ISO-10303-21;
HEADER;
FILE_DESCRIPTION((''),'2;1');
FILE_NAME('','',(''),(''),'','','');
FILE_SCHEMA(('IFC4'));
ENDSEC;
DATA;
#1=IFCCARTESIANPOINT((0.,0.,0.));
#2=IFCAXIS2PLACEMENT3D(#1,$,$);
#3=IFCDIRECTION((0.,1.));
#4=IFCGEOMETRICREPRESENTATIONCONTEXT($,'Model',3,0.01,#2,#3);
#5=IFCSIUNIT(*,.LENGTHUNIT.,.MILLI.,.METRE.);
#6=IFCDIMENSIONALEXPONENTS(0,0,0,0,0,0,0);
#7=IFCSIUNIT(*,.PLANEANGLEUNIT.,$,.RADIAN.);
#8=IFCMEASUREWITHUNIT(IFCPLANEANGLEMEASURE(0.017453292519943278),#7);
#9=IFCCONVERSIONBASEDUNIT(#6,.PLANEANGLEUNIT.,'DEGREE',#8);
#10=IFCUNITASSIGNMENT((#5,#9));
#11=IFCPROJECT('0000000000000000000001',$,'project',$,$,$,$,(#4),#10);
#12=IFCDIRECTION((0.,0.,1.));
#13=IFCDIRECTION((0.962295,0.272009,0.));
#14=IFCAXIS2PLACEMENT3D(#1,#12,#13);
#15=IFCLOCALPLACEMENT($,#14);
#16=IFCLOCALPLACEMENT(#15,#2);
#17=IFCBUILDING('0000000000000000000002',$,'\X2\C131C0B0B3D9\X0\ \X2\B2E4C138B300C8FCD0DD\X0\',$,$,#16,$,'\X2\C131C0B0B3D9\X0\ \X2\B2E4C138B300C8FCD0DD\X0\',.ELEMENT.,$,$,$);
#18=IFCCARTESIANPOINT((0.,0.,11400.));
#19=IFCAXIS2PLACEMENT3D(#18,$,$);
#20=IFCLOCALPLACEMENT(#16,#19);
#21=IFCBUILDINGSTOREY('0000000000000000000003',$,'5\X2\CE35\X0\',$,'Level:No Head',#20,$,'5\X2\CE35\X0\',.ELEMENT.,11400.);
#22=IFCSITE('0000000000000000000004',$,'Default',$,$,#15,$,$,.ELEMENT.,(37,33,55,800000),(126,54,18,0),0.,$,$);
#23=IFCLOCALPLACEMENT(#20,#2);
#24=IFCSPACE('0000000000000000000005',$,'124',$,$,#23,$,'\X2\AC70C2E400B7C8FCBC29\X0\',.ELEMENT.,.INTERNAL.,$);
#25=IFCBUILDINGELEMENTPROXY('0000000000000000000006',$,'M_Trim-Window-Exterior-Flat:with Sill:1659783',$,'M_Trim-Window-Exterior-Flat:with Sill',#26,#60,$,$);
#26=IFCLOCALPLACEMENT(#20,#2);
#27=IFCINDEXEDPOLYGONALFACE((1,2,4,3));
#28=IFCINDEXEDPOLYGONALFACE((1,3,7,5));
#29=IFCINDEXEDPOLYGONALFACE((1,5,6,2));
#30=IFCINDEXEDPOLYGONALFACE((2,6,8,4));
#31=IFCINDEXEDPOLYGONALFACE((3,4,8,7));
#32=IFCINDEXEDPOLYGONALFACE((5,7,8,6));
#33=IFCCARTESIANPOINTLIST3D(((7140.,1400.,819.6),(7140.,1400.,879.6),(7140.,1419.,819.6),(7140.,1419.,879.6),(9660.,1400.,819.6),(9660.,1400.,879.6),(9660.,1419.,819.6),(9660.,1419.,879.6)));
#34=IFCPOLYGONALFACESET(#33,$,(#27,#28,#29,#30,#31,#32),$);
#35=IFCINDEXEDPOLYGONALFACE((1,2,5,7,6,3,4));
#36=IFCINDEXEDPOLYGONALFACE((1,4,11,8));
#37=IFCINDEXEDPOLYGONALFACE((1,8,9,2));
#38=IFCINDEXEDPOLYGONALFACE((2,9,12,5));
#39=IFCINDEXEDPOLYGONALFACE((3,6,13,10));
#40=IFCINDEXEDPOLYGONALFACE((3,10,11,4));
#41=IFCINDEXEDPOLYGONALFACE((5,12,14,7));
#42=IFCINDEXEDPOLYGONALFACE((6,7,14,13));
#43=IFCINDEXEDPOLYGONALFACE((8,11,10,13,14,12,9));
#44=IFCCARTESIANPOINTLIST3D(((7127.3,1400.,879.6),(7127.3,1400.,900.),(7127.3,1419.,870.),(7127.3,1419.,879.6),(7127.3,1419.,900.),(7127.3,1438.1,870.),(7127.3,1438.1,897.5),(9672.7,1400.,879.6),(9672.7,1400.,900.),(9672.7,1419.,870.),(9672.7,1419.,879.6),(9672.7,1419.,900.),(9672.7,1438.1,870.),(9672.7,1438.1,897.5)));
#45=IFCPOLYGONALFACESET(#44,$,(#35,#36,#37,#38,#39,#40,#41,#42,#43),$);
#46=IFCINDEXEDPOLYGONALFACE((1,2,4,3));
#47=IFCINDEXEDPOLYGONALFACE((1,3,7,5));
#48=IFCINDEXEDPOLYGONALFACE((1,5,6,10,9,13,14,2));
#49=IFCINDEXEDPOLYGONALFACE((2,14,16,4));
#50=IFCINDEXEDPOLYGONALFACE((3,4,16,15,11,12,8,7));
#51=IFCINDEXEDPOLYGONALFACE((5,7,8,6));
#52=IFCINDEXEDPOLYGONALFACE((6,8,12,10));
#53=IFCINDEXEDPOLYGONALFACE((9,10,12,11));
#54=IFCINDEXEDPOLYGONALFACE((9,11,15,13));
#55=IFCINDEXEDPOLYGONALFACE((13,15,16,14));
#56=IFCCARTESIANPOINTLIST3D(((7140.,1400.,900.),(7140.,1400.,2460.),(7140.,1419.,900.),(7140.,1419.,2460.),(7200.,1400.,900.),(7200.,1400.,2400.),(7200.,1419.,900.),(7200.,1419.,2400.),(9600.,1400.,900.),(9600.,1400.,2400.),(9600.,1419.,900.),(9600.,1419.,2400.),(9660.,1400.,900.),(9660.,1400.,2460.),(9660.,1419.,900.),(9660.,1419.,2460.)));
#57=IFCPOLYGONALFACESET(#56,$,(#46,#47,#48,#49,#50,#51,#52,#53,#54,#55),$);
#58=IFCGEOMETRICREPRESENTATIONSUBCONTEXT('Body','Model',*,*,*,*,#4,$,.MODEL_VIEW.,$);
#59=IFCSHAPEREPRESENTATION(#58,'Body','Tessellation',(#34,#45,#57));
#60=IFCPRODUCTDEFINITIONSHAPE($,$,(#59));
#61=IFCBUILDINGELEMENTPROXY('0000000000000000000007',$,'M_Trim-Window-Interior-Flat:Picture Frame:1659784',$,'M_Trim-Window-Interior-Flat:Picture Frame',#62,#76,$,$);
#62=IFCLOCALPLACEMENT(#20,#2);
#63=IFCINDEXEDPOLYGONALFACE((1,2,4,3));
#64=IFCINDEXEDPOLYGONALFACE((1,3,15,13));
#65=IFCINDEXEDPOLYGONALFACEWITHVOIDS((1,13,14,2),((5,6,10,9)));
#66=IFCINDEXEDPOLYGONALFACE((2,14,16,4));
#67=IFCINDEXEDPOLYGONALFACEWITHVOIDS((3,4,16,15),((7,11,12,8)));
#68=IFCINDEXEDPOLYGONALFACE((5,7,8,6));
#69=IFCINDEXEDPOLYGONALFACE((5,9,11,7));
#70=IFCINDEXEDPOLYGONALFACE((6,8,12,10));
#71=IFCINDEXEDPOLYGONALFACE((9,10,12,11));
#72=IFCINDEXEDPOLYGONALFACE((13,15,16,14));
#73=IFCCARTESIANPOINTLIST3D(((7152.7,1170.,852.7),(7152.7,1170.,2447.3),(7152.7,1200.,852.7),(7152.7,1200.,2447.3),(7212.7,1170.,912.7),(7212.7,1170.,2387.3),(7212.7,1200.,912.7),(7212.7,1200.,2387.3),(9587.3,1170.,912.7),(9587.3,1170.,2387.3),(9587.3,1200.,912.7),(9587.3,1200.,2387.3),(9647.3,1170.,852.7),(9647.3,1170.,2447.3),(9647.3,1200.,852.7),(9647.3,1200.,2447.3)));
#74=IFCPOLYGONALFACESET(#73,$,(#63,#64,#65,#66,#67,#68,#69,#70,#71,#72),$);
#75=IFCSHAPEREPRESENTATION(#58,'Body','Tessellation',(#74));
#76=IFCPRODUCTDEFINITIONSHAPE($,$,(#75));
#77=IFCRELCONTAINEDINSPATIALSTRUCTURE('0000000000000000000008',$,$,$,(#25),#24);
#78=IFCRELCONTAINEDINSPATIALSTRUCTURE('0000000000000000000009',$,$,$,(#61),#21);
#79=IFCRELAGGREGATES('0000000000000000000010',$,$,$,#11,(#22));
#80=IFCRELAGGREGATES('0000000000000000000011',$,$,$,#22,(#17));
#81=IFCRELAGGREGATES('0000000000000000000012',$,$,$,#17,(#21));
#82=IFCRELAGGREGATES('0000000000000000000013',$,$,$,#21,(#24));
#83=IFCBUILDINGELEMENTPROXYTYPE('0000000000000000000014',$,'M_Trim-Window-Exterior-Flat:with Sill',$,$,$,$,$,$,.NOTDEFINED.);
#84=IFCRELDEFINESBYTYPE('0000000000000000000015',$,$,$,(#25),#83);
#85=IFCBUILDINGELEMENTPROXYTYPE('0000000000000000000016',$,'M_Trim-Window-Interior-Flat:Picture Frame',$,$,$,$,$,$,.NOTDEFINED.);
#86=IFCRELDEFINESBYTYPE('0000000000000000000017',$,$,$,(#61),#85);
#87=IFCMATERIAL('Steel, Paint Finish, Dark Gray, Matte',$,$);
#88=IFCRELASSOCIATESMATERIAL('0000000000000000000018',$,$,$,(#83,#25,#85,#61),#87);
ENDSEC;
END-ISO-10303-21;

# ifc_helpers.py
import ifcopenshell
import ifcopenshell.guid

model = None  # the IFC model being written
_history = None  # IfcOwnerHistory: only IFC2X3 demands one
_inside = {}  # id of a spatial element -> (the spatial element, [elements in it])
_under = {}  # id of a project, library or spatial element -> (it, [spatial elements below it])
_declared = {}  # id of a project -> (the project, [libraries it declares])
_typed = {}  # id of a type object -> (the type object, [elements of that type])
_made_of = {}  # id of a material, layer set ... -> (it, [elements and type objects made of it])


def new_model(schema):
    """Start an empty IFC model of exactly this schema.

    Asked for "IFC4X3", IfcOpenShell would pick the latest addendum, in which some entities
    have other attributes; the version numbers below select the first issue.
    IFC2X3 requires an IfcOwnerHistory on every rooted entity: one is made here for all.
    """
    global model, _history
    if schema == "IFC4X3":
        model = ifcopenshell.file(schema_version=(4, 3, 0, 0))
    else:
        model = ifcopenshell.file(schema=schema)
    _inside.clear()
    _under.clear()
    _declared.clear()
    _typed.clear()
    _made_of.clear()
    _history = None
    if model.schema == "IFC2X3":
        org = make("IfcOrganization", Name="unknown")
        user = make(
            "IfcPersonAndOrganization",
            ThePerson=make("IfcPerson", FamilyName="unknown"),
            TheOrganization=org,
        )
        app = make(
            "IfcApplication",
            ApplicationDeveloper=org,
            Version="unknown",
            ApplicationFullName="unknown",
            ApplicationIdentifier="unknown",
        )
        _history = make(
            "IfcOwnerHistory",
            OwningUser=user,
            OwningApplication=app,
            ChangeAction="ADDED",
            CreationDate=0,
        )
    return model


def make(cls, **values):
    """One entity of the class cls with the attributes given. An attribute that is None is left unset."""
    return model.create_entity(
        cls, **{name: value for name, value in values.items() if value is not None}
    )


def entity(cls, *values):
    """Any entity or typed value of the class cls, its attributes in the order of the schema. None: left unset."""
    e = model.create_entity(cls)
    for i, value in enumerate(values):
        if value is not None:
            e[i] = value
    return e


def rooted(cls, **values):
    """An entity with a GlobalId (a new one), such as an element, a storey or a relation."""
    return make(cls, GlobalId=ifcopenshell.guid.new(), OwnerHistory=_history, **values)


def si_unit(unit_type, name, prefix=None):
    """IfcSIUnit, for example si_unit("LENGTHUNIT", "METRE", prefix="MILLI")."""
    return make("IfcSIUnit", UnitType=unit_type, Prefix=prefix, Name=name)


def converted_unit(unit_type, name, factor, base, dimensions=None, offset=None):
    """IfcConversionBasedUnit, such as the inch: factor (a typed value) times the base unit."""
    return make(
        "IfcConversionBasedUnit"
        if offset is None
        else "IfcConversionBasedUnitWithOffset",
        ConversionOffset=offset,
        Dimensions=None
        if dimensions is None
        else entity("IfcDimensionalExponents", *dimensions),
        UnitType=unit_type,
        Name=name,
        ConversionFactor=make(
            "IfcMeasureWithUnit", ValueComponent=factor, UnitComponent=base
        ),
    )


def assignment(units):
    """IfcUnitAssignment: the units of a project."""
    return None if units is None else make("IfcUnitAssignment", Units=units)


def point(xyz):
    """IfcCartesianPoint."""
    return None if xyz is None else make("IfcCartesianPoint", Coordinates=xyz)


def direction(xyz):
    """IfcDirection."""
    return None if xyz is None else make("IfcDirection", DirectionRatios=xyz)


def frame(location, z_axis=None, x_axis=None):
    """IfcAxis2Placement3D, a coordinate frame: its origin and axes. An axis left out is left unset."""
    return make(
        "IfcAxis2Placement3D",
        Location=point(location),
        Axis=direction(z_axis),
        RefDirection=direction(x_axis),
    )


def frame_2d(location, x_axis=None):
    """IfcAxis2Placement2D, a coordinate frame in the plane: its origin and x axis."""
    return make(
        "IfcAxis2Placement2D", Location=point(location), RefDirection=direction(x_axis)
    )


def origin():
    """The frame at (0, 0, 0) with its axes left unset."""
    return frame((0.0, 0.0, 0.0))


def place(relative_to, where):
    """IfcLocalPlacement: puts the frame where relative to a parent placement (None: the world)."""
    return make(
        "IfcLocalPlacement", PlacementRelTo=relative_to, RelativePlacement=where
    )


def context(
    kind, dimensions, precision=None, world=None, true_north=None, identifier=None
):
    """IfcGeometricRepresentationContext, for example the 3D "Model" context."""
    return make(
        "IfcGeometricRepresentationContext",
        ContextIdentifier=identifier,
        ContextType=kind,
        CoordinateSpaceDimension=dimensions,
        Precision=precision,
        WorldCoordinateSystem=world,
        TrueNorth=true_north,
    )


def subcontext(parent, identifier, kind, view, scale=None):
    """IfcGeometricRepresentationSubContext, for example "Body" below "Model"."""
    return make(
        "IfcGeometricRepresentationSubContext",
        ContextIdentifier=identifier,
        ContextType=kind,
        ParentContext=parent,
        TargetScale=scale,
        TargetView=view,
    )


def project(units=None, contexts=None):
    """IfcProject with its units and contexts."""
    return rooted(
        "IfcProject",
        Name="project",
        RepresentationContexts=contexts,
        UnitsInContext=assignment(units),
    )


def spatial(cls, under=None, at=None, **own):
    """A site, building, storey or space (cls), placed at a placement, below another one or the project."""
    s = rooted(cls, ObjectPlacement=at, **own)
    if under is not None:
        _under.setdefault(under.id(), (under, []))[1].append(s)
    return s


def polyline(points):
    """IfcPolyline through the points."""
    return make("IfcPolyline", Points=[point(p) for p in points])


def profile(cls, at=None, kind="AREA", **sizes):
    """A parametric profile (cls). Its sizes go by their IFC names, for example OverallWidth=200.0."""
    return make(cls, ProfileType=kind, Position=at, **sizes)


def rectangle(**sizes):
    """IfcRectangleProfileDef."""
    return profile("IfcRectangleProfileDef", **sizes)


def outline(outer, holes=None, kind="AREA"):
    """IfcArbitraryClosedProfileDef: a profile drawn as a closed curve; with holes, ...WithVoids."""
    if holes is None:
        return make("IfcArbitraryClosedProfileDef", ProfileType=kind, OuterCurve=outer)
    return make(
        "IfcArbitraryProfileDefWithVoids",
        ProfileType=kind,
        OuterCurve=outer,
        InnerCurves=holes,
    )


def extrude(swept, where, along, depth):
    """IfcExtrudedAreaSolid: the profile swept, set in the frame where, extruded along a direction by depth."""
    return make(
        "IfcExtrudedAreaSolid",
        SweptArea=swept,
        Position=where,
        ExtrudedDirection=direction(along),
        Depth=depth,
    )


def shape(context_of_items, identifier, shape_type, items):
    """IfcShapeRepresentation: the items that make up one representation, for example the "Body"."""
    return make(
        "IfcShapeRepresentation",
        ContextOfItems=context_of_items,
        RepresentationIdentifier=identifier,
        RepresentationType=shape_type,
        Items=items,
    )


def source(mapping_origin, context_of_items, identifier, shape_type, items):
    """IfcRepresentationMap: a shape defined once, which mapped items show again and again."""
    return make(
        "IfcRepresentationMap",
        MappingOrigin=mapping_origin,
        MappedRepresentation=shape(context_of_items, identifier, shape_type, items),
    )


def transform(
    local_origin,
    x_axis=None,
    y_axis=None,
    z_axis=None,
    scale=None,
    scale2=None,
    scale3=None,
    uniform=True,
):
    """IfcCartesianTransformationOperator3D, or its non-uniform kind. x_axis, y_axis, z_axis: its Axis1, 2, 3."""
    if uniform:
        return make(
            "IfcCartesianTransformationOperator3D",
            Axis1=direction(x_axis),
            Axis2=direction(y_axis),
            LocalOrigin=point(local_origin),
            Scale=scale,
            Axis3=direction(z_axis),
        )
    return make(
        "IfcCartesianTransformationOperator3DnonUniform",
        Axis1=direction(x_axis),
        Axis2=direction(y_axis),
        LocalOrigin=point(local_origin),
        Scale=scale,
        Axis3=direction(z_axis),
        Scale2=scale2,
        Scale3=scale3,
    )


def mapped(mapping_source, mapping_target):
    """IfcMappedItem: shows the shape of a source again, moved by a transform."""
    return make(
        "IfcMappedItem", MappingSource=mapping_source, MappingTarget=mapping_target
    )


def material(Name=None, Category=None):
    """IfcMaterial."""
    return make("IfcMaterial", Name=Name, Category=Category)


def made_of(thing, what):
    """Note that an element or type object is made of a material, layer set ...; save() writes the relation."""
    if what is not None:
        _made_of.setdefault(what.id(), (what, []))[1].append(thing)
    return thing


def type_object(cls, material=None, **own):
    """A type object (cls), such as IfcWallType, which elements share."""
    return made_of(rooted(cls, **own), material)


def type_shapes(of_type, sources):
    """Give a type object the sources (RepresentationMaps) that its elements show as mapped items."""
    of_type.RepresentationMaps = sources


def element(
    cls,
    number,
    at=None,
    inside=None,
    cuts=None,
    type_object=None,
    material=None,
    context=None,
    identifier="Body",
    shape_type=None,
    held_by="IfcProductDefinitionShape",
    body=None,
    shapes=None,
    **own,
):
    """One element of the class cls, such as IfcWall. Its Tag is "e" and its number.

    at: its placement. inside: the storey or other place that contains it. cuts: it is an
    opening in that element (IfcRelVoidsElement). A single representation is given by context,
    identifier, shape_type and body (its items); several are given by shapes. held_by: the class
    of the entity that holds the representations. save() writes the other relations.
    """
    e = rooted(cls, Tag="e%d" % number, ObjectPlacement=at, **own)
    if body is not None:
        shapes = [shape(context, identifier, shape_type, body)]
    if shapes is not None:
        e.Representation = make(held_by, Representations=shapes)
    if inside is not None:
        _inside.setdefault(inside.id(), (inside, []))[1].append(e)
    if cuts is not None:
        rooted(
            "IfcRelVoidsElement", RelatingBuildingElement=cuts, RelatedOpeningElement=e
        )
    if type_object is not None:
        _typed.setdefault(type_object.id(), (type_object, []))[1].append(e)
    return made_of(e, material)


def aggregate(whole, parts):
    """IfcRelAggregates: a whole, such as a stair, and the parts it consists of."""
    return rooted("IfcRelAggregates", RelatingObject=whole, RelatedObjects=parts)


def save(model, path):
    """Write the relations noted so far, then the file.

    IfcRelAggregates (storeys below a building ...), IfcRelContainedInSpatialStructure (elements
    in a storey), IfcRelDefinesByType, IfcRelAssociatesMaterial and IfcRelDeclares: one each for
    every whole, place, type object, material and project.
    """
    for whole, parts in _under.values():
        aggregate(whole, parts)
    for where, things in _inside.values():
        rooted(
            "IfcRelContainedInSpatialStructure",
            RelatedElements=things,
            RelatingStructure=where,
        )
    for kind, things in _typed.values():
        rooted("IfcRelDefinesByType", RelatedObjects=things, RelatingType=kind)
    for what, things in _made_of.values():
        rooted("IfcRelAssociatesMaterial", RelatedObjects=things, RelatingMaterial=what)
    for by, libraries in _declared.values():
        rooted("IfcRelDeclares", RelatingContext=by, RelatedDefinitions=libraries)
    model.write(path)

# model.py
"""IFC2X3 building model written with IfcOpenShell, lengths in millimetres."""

from ifc_helpers import new_model, entity, si_unit, converted_unit, direction, frame, frame_2d, origin, place, context, subcontext, project, spatial, polyline, rectangle, outline, extrude, source, transform, mapped, material, type_object, type_shapes, element, save


model = new_model("IFC2X3")

# Units and contexts
model_context = context("Model", 3, precision=0.01, world=origin(), true_north=direction((0.0, 1.0)))
body_context = subcontext(model_context, "Body", "Model", "MODEL_VIEW")
ifc_project = project(units=[si_unit("LENGTHUNIT", "METRE", prefix="MILLI"), converted_unit("PLANEANGLEUNIT", "DEGREE", entity("IfcPlaneAngleMeasure", 0.017453292519943278), si_unit("PLANEANGLEUNIT", "RADIAN"), dimensions=[0, 0, 0, 0, 0, 0, 0])], contexts=[model_context])

# Site, building, storey
site_placement = place(None, frame((0.0, 0.0, 0.0), z_axis=(0.0, 0.0, 1.0), x_axis=(0.962295, 0.272009, 0.0)))
site = spatial("IfcSite", under=ifc_project, at=site_placement, Name="Default", CompositionType="ELEMENT", RefLatitude=(37, 33, 55, 800000), RefLongitude=(126, 54, 18, 0), RefElevation=0.0)
building_placement = place(site_placement, origin())
building = spatial("IfcBuilding", under=site, at=building_placement, Name="성산동 다세대주택", LongName="성산동 다세대주택", CompositionType="ELEMENT")
storey_placement = place(building_placement, frame((0.0, 0.0, 11400.0)))
storey = spatial("IfcBuildingStorey", under=building, at=storey_placement, Name="5층", ObjectType="Level:No Head", LongName="5층", CompositionType="ELEMENT", Elevation=11400.0)

# Shared definitions
ifc_material_1 = material(Name="Steel, Paint Finish, Dark Gray, Matte")

# Shared definitions
space_1_placement = place(storey_placement, origin())
space_1 = spatial("IfcSpace", under=storey, at=space_1_placement, Name="124", LongName="거실·주방", CompositionType="ELEMENT", InteriorOrExteriorSpace="INTERNAL")

# Building element proxies
building_element_proxy_type_1 = type_object("IfcBuildingElementProxyType", Name="M_Trim-Window-Exterior-Flat:with Sill", PredefinedType="NOTDEFINED", material=ifc_material_1)
shared_shape_1 = source(origin(), body_context, "Body", "SweptSolid", [
    extrude(rectangle(XDim=2520.0, YDim=60.0, at=frame_2d((0.0, 0.0), x_axis=(1.0, 0.0))), frame((0.0, -1550.4, 0.0), z_axis=(0.0, 0.0, 1.0), x_axis=(-1.0, 0.0, 0.0)), (0.0, 0.0, 1.0), 19.0),
    extrude(outline(polyline([(-19.0, -15.2), (0.0, -15.2), (0.0, -5.7), (19.0, -5.7), (19.0, 14.8), (0.0, 14.8), (-19.0, 12.3), (-19.0, -15.2)])), frame((-1272.7, -1514.8, 19.0), z_axis=(1.0, 0.0, 0.0), x_axis=(0.0, 0.0, -1.0)), (0.0, 0.0, 1.0), 2545.4),
    extrude(outline(polyline([(-795.0, -1260.0), (765.0, -1260.0), (765.0, -1200.0), (-735.0, -1200.0), (-735.0, 1200.0), (765.0, 1200.0), (765.0, 1260.0), (-795.0, 1260.0), (-795.0, -1260.0)])), frame((0.0, -735.0, 0.0), z_axis=(0.0, 0.0, 1.0), x_axis=(0.0, -1.0, 0.0)), (0.0, 0.0, 1.0), 19.0),
])
type_shapes(building_element_proxy_type_1, [shared_shape_1])
proxy_1_placement = place(space_1_placement, frame((8400.0, 1400.0, 2400.0), z_axis=(0.0, 1.0, 0.0), x_axis=(-1.0, 0.0, 0.0)))
element("IfcBuildingElementProxy", 1, at=proxy_1_placement, inside=space_1, type_object=building_element_proxy_type_1, material=ifc_material_1, Name="M_Trim-Window-Exterior-Flat:with Sill:1659783", ObjectType="M_Trim-Window-Exterior-Flat:with Sill", context=body_context, shape_type="MappedRepresentation", body=[
    mapped(shared_shape_1, transform((0.0, 0.0, 0.0), scale=1.0)),
])
building_element_proxy_type_2 = type_object("IfcBuildingElementProxyType", Name="M_Trim-Window-Interior-Flat:Picture Frame", PredefinedType="NOTDEFINED", material=ifc_material_1)
shared_shape_2 = source(origin(), body_context, "Body", "SweptSolid", [
    extrude(outline(polyline([(-1247.3, -797.3), (1247.3, -797.3), (1247.3, 797.3), (-1247.3, 797.3), (-1247.3, -797.3)]), holes=[polyline([(-1187.3, -737.3), (-1187.3, 737.3), (1187.3, 737.3), (1187.3, -737.3), (-1187.3, -737.3)])]), frame((0.0, -750.0, 0.0), z_axis=(0.0, 0.0, 1.0), x_axis=(-1.0, 0.0, 0.0)), (0.0, 0.0, 1.0), 30.0),
])
type_shapes(building_element_proxy_type_2, [shared_shape_2])
proxy_2_placement = place(storey_placement, frame((8400.0, 1200.0, 2400.0), z_axis=(0.0, -1.0, 0.0), x_axis=(1.0, 0.0, 0.0)))
element("IfcBuildingElementProxy", 2, at=proxy_2_placement, inside=storey, type_object=building_element_proxy_type_2, material=ifc_material_1, Name="M_Trim-Window-Interior-Flat:Picture Frame:1659784", ObjectType="M_Trim-Window-Interior-Flat:Picture Frame", context=body_context, shape_type="MappedRepresentation", body=[
    mapped(shared_shape_2, transform((0.0, 0.0, 0.0), scale=1.0)),
])

save(model, "model.ifc")
